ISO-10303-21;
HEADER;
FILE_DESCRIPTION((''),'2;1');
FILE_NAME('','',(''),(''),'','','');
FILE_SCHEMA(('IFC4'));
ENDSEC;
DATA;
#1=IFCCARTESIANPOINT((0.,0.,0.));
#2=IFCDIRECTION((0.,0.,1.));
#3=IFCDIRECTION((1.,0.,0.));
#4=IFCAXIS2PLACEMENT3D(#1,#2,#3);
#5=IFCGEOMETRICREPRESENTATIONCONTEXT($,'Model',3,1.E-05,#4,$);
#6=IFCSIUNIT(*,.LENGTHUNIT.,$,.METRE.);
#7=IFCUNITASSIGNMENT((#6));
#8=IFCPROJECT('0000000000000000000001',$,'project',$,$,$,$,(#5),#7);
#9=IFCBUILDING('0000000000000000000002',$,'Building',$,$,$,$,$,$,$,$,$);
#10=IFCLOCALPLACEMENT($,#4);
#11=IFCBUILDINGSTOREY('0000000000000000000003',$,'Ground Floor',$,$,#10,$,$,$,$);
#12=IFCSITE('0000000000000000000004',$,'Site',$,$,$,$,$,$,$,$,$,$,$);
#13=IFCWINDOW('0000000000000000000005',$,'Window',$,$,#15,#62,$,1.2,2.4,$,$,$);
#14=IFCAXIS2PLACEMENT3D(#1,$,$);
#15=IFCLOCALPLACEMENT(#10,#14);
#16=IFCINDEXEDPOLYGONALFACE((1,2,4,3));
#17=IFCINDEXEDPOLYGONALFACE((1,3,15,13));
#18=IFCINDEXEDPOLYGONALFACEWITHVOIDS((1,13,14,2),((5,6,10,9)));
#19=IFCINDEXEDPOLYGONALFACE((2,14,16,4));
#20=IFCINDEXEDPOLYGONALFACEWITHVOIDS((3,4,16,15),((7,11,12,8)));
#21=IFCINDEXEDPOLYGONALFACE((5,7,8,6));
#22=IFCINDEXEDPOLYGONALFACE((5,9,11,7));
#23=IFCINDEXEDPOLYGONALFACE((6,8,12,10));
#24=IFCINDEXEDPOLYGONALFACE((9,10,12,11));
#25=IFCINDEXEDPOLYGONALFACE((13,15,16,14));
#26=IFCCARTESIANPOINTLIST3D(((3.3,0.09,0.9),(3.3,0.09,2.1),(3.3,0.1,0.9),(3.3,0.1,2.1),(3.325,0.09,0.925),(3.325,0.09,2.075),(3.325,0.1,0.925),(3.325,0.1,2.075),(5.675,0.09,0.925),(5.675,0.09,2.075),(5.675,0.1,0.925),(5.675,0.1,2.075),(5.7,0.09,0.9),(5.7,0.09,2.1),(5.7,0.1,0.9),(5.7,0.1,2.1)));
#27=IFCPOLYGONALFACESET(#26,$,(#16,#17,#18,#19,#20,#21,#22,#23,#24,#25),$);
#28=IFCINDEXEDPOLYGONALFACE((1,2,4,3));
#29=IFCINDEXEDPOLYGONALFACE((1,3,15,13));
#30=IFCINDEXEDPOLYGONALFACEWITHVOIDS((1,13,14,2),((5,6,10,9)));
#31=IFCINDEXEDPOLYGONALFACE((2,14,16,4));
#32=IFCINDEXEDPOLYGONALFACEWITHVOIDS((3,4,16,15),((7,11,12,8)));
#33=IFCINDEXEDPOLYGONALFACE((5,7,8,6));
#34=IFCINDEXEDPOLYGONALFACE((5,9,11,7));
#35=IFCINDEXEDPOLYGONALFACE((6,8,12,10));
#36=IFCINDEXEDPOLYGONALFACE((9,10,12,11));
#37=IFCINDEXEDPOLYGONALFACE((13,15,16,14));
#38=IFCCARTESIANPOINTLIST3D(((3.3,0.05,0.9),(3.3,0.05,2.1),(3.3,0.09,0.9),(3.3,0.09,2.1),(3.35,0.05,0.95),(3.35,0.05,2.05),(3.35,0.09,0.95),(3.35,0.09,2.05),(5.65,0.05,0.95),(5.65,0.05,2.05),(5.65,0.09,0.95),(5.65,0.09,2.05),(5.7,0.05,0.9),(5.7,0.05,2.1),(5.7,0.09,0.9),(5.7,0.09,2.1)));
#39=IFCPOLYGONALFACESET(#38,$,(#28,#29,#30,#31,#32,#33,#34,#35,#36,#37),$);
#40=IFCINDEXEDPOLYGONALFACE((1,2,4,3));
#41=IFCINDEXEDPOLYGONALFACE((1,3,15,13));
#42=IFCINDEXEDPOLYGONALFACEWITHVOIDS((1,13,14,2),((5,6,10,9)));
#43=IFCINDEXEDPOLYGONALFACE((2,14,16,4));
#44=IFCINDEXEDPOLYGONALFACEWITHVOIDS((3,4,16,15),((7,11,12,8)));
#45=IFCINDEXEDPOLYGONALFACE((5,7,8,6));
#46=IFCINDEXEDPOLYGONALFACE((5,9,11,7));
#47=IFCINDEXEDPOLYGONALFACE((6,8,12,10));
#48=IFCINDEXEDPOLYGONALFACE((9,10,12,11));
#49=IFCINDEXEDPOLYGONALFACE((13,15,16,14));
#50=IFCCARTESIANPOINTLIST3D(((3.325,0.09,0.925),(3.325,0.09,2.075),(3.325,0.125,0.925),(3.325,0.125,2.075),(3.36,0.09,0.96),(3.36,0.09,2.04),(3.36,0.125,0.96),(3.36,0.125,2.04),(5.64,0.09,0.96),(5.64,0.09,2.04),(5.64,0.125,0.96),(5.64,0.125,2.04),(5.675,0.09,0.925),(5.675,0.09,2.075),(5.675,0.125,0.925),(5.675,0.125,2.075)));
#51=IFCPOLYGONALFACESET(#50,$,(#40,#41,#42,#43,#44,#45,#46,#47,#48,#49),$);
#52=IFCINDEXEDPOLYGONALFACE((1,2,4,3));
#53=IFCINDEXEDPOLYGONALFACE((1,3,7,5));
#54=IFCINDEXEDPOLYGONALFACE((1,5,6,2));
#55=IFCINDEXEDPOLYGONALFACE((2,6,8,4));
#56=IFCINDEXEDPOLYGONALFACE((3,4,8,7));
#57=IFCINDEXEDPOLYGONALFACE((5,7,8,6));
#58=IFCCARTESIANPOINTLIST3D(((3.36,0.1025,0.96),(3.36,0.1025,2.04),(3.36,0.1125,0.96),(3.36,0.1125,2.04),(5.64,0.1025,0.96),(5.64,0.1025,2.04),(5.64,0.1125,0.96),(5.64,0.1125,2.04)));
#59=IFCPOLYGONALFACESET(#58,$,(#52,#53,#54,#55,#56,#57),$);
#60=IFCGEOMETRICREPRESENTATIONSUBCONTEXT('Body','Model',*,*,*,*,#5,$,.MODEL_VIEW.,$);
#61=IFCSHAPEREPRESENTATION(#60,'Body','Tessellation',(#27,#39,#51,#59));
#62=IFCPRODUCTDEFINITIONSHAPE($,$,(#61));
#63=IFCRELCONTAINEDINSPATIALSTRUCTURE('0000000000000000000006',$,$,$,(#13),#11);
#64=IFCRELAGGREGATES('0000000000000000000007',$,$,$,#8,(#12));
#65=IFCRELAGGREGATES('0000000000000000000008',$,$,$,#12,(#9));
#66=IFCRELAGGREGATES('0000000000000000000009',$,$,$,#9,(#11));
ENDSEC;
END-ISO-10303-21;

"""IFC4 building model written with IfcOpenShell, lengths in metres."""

from ifc_helpers import new_model, si_unit, frame, origin_with_axes, place, context, subcontext, project, spatial, line, indexed_curve, outline, extrude, element, save


model = new_model("IFC4")

# Units and contexts
model_context = context("Model", 3, precision=1e-05, world=origin_with_axes())
body_context = subcontext(model_context, "Body", "Model", "MODEL_VIEW")
ifc_project = project(units=[si_unit("LENGTHUNIT", "METRE")], contexts=[model_context])

# Site, building, storey
site = spatial("IfcSite", under=ifc_project, Name="Site")
building = spatial("IfcBuilding", under=site, Name="Building")
storey_placement = place(None, origin_with_axes())
storey = spatial("IfcBuildingStorey", under=building, at=storey_placement, Name="Ground Floor")

# Window
window_placement = place(storey_placement, frame((3.3, 0.0, 0.9), z_axis=(0.0, 0.0, 1.0), x_axis=(1.0, 0.0, 0.0)))
element("IfcWindow", 1, at=window_placement, inside=storey, Name="Window", OverallHeight=1.2, OverallWidth=2.4, context=body_context, shape_type="SweptSolid", body=[
    extrude(outline(indexed_curve([(0.0, 0.0), (2.4, 0.0), (2.4, 1.2), (0.0, 1.2)], segments=[line(1, 2, 3, 4, 1)]), holes=[indexed_curve([(0.025, 0.025), (2.375, 0.025), (2.375, 1.175), (0.025, 1.175)], segments=[line(1, 2, 3, 4, 1)])]), frame((0.0, 0.09, 0.0), z_axis=(0.0, -1.0, 0.0), x_axis=(1.0, 0.0, 0.0)), (0.0, 0.0, -1.0), 0.01),
    extrude(outline(indexed_curve([(0.0, 0.0), (2.4, 0.0), (2.4, 1.2), (0.0, 1.2)], segments=[line(1, 2, 3, 4, 1)]), holes=[indexed_curve([(0.05, 0.05), (2.35, 0.05), (2.35, 1.15), (0.05, 1.15)], segments=[line(1, 2, 3, 4, 1)])]), frame((0.0, 0.05, 0.0), z_axis=(0.0, -1.0, 0.0), x_axis=(1.0, 0.0, 0.0)), (0.0, 0.0, -1.0), 0.04),
    extrude(outline(indexed_curve([(0.0, 0.0), (2.35, 0.0), (2.35, 1.15), (0.0, 1.15)], segments=[line(1, 2, 3, 4, 1)]), holes=[indexed_curve([(0.035, 0.035), (2.315, 0.035), (2.315, 1.115), (0.035, 1.115)], segments=[line(1, 2, 3, 4, 1)])]), frame((0.025, 0.09, 0.025), z_axis=(0.0, -1.0, 0.0), x_axis=(1.0, 0.0, 0.0)), (0.0, 0.0, -1.0), 0.035),
    extrude(outline(indexed_curve([(0.035, 0.035), (2.315, 0.035), (2.315, 1.115), (0.035, 1.115)], segments=[line(1, 2, 3, 4, 1)])), frame((0.025, 0.1025, 0.025), z_axis=(0.0, -1.0, 0.0), x_axis=(1.0, 0.0, 0.0)), (0.0, 0.0, -1.0), 0.01),
])

save(model, "model.ifc")
